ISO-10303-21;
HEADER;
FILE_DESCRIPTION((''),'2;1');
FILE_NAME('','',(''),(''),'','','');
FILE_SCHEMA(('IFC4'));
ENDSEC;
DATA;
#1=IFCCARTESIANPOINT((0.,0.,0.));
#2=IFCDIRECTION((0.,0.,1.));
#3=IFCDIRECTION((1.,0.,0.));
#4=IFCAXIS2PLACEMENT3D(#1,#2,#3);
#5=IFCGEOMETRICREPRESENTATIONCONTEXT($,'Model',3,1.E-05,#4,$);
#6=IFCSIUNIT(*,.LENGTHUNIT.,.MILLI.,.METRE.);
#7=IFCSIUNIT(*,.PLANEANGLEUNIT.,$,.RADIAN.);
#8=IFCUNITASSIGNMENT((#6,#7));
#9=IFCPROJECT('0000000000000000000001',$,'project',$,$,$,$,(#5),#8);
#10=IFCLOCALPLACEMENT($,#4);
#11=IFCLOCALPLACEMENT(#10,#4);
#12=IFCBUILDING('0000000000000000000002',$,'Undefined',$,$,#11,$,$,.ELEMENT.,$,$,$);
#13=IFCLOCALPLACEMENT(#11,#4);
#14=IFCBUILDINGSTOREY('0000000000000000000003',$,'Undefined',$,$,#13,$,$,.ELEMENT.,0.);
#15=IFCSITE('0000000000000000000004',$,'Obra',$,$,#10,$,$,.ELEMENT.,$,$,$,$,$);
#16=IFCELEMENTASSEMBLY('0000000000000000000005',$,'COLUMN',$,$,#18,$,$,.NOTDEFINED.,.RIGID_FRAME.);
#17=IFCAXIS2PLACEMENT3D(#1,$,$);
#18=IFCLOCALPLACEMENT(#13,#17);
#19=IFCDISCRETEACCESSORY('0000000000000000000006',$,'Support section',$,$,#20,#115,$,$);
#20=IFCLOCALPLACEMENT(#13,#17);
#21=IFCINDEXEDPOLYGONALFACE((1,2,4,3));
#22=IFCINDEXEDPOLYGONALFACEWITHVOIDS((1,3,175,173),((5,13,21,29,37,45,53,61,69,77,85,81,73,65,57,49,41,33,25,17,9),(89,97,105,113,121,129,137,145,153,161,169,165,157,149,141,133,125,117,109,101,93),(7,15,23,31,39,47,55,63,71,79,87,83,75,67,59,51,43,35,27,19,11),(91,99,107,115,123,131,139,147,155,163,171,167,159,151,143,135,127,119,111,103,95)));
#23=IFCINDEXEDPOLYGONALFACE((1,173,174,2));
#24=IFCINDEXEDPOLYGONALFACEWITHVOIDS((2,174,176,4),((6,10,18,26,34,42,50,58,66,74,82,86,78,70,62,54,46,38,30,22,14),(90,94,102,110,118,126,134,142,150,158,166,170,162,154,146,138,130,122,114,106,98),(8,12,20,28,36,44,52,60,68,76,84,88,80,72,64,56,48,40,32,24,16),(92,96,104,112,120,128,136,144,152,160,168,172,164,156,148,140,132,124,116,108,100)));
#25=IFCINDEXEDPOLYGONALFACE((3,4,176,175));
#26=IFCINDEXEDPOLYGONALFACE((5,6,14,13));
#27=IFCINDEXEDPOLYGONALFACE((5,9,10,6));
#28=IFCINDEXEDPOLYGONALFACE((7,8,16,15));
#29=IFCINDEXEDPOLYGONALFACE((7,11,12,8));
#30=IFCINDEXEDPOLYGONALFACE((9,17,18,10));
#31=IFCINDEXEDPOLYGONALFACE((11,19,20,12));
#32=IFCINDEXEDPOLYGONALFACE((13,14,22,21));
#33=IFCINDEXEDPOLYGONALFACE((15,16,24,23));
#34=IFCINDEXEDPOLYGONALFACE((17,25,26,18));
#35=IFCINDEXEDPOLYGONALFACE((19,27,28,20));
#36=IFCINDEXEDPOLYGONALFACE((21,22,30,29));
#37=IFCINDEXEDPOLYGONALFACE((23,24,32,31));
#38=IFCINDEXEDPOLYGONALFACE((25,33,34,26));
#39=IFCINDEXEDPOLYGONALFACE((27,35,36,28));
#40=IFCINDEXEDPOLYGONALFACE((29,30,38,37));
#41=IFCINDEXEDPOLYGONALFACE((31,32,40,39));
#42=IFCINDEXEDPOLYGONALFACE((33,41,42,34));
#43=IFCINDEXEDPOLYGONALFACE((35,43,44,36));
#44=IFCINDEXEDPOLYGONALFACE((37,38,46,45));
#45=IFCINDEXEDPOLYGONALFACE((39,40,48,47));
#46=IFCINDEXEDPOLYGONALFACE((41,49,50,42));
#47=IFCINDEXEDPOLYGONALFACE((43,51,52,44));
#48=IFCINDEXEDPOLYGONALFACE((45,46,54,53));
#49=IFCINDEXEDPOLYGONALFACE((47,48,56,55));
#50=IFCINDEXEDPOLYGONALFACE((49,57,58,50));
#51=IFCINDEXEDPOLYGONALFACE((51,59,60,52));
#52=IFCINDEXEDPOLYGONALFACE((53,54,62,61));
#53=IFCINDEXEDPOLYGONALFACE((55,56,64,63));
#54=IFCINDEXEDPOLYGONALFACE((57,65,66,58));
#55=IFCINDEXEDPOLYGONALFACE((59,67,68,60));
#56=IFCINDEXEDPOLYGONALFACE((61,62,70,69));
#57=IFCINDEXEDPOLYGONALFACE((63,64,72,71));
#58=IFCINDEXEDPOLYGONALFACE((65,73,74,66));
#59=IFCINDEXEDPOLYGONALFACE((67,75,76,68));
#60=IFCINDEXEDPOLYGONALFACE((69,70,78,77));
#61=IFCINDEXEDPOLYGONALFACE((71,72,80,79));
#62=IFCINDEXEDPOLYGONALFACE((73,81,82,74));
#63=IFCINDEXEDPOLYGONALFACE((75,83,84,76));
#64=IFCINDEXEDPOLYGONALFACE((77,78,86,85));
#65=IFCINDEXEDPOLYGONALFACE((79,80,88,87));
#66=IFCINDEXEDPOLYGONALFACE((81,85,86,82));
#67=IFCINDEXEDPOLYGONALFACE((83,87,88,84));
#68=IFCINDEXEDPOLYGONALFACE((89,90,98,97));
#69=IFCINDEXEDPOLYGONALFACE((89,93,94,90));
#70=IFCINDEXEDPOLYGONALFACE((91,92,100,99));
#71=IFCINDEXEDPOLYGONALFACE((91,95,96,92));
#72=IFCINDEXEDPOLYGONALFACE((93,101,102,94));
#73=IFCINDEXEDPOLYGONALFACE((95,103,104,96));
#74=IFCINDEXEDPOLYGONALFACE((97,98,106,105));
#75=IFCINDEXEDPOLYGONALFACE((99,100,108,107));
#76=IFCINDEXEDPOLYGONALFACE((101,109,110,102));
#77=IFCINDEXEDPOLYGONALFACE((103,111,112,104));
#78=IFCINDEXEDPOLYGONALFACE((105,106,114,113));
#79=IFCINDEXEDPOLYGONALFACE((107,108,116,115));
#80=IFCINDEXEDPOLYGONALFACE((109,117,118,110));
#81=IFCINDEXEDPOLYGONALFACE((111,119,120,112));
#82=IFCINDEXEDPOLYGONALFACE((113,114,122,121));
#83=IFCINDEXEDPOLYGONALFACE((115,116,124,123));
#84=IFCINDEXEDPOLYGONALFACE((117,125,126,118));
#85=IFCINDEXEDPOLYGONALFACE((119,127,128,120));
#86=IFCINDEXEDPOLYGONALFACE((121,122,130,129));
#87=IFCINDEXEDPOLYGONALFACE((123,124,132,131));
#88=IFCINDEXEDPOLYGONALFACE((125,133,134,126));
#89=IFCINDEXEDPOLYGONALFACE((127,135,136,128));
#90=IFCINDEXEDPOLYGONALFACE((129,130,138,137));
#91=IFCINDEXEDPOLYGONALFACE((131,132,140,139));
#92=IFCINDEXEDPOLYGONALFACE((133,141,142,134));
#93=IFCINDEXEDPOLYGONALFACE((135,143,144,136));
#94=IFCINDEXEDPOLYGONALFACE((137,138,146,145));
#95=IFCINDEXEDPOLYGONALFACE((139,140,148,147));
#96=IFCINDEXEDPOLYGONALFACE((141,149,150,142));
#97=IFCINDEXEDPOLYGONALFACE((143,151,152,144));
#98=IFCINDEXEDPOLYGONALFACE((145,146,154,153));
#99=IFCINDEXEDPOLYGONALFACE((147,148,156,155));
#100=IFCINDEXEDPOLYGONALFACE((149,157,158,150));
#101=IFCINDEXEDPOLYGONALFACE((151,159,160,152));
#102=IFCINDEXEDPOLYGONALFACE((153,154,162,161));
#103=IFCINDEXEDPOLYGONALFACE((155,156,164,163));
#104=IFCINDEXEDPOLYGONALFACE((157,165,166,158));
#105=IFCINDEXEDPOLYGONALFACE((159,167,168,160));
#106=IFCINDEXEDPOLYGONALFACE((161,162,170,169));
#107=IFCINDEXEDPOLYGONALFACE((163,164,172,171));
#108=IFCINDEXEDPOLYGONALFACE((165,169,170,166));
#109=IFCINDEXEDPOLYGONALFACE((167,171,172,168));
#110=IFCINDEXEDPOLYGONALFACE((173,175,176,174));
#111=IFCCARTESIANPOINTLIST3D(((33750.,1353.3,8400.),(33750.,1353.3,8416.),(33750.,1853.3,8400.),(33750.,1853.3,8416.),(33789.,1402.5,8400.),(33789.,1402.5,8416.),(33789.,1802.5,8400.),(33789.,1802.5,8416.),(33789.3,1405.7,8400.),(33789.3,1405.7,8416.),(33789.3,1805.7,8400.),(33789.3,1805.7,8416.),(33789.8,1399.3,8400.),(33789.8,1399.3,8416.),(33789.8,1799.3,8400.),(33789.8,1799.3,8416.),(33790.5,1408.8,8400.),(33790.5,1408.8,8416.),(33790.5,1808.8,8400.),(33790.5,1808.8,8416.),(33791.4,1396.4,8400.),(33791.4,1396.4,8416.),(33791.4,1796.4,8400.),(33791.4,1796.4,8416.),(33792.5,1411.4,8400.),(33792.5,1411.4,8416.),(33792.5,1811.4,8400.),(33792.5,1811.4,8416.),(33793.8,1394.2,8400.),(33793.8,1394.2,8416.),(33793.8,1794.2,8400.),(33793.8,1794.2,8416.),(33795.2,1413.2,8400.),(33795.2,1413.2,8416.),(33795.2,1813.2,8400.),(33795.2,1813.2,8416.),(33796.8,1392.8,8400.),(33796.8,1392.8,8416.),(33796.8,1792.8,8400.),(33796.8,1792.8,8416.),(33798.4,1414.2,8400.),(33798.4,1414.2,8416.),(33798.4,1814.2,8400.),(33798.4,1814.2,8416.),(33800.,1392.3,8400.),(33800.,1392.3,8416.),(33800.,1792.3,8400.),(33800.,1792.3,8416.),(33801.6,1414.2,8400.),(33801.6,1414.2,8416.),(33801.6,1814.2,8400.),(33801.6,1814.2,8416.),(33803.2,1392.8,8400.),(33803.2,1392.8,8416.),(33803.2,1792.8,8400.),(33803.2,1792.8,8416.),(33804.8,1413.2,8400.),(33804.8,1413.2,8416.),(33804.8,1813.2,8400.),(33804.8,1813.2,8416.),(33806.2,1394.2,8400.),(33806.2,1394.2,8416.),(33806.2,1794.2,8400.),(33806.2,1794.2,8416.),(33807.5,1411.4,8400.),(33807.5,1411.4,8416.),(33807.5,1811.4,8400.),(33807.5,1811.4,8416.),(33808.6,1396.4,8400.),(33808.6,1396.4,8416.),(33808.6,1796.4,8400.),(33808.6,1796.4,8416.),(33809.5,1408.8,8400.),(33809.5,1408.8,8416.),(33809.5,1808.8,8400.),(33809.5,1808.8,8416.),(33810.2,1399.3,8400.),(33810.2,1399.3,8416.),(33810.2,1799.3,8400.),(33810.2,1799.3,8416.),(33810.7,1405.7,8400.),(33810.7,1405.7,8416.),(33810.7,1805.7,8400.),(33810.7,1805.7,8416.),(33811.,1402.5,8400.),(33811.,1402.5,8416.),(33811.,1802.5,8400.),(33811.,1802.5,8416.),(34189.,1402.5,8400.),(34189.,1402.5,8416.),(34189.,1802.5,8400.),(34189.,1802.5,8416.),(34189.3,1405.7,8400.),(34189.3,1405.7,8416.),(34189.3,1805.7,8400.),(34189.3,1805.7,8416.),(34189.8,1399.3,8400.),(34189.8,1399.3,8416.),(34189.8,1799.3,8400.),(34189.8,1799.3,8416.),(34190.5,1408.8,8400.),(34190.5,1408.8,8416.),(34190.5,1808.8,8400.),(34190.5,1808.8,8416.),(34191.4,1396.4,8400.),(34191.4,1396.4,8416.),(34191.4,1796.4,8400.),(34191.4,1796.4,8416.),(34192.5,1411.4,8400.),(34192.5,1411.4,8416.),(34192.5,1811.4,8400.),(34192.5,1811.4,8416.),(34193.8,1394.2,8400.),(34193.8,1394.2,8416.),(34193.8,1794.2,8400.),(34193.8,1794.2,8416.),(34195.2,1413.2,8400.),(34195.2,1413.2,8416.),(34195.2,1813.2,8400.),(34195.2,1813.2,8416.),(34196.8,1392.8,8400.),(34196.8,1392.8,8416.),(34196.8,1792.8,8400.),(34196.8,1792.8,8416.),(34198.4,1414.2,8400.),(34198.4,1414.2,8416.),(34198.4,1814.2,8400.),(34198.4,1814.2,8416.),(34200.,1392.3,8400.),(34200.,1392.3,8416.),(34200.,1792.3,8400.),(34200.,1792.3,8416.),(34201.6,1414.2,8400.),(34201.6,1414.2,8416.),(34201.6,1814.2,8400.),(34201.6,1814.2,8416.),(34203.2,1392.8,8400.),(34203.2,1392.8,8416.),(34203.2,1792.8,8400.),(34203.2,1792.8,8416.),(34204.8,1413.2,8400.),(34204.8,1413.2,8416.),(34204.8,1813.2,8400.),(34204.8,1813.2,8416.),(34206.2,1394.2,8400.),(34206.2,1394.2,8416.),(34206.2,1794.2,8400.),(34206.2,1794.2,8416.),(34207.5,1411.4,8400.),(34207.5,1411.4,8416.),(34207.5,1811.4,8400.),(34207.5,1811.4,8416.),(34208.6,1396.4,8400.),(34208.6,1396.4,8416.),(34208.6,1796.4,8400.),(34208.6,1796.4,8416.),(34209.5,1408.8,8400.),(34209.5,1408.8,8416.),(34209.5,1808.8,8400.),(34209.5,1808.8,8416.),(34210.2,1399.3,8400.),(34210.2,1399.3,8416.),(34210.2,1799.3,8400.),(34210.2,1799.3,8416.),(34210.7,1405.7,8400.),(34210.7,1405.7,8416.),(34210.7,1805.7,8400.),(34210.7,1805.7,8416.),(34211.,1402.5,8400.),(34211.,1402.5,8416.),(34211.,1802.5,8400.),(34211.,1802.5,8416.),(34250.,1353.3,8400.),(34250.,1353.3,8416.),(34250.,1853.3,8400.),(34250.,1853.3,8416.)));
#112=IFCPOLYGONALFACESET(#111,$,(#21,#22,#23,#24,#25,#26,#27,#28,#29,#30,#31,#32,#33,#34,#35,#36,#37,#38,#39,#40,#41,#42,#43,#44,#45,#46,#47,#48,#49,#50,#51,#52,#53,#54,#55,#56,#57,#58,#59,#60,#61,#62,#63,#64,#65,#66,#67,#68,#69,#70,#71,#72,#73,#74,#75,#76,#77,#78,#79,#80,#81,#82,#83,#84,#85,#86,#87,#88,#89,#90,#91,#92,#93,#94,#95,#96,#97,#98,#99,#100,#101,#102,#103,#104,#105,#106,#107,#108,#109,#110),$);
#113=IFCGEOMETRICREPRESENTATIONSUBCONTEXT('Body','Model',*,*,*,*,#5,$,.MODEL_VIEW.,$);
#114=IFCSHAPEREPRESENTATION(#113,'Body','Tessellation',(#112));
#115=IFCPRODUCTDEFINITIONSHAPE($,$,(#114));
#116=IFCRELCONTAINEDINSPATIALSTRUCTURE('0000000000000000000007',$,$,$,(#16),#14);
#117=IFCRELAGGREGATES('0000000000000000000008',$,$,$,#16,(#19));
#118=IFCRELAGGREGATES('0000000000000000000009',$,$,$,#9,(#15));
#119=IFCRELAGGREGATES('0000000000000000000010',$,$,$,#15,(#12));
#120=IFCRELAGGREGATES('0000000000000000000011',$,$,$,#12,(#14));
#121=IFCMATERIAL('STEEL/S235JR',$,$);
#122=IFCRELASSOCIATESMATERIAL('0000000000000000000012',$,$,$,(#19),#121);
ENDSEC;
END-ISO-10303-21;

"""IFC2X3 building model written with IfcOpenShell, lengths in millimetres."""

from ifc_helpers import new_model, si_unit, frame, origin_with_axes, origin_2d_with_axis, place, context, subcontext, project, spatial, rectangle, circle, extrude, source, transform, mapped, material, element, aggregate, save


model = new_model("IFC2X3")

# Units and contexts
model_context = context("Model", 3, precision=1e-05, world=origin_with_axes())
body_context = subcontext(model_context, "Body", "Model", "MODEL_VIEW")
ifc_project = project(units=[si_unit("LENGTHUNIT", "METRE", prefix="MILLI"), si_unit("PLANEANGLEUNIT", "RADIAN")], contexts=[model_context])

# Site, building, storey
site_placement = place(None, origin_with_axes())
site = spatial("IfcSite", under=ifc_project, at=site_placement, Name="Obra", CompositionType="ELEMENT")
building_placement = place(site_placement, origin_with_axes())
building = spatial("IfcBuilding", under=site, at=building_placement, Name="Undefined", CompositionType="ELEMENT")
storey_placement = place(building_placement, origin_with_axes())
storey = spatial("IfcBuildingStorey", under=building, at=storey_placement, Name="Undefined", CompositionType="ELEMENT", Elevation=0.0)

# Element assembly
assembly_1_placement = place(storey_placement, origin_with_axes())
assembly_1 = element("IfcElementAssembly", 1, at=assembly_1_placement, inside=storey, Name="COLUMN", AssemblyPlace="NOTDEFINED", PredefinedType="RIGID_FRAME")
ifc_material_1 = material(Name="STEEL/S235JR")

# Discrete accessory, opening
discrete_accessory_1_placement = place(assembly_1_placement, frame((34000.0, 1353.3, 8408.0), z_axis=(-1.0, 0.0, 0.0), x_axis=(0.0, 1.0, 0.0)))
discrete_accessory_1 = element("IfcDiscreteAccessory", 2, at=discrete_accessory_1_placement, material=ifc_material_1, Name="Support section", context=body_context, shape_type="SweptSolid", body=[
    extrude(rectangle(XDim=16.0, YDim=500.0, at=origin_2d_with_axis()), frame((500.0, 0.0, 0.0), z_axis=(-1.0, 0.0, 0.0), x_axis=(0.0, -1.0, 0.0)), (0.0, 0.0, 1.0), 500.0),
])
shared_shape_1 = source(origin_with_axes(), body_context, "Body", "SweptSolid", [
    extrude(circle(Radius=11.0, at=origin_2d_with_axis()), frame((0.0, -0.1, 0.0), z_axis=(0.0, 1.0, 0.0), x_axis=(1.0, 0.0, 0.0)), (0.0, 0.0, 1.0), 16.2),
])
opening_1_placement = place(assembly_1_placement, frame((34000.0, 1806.3, 8416.0), z_axis=(1.0, 0.0, 0.0), x_axis=(0.0, -1.0, 0.0)))
element("IfcOpeningElement", 3, at=opening_1_placement, cuts=discrete_accessory_1, ObjectType="Opening", context=body_context, shape_type="MappedRepresentation", body=[
    mapped(shared_shape_1, transform((3.0, 0.0, 200.0))),
    mapped(shared_shape_1, transform((3.0, 0.0, -200.0))),
    mapped(shared_shape_1, transform((403.0, 0.0, 200.0))),
    mapped(shared_shape_1, transform((403.0, 0.0, -200.0))),
])
aggregate(assembly_1, [discrete_accessory_1])

save(model, "model.ifc")
